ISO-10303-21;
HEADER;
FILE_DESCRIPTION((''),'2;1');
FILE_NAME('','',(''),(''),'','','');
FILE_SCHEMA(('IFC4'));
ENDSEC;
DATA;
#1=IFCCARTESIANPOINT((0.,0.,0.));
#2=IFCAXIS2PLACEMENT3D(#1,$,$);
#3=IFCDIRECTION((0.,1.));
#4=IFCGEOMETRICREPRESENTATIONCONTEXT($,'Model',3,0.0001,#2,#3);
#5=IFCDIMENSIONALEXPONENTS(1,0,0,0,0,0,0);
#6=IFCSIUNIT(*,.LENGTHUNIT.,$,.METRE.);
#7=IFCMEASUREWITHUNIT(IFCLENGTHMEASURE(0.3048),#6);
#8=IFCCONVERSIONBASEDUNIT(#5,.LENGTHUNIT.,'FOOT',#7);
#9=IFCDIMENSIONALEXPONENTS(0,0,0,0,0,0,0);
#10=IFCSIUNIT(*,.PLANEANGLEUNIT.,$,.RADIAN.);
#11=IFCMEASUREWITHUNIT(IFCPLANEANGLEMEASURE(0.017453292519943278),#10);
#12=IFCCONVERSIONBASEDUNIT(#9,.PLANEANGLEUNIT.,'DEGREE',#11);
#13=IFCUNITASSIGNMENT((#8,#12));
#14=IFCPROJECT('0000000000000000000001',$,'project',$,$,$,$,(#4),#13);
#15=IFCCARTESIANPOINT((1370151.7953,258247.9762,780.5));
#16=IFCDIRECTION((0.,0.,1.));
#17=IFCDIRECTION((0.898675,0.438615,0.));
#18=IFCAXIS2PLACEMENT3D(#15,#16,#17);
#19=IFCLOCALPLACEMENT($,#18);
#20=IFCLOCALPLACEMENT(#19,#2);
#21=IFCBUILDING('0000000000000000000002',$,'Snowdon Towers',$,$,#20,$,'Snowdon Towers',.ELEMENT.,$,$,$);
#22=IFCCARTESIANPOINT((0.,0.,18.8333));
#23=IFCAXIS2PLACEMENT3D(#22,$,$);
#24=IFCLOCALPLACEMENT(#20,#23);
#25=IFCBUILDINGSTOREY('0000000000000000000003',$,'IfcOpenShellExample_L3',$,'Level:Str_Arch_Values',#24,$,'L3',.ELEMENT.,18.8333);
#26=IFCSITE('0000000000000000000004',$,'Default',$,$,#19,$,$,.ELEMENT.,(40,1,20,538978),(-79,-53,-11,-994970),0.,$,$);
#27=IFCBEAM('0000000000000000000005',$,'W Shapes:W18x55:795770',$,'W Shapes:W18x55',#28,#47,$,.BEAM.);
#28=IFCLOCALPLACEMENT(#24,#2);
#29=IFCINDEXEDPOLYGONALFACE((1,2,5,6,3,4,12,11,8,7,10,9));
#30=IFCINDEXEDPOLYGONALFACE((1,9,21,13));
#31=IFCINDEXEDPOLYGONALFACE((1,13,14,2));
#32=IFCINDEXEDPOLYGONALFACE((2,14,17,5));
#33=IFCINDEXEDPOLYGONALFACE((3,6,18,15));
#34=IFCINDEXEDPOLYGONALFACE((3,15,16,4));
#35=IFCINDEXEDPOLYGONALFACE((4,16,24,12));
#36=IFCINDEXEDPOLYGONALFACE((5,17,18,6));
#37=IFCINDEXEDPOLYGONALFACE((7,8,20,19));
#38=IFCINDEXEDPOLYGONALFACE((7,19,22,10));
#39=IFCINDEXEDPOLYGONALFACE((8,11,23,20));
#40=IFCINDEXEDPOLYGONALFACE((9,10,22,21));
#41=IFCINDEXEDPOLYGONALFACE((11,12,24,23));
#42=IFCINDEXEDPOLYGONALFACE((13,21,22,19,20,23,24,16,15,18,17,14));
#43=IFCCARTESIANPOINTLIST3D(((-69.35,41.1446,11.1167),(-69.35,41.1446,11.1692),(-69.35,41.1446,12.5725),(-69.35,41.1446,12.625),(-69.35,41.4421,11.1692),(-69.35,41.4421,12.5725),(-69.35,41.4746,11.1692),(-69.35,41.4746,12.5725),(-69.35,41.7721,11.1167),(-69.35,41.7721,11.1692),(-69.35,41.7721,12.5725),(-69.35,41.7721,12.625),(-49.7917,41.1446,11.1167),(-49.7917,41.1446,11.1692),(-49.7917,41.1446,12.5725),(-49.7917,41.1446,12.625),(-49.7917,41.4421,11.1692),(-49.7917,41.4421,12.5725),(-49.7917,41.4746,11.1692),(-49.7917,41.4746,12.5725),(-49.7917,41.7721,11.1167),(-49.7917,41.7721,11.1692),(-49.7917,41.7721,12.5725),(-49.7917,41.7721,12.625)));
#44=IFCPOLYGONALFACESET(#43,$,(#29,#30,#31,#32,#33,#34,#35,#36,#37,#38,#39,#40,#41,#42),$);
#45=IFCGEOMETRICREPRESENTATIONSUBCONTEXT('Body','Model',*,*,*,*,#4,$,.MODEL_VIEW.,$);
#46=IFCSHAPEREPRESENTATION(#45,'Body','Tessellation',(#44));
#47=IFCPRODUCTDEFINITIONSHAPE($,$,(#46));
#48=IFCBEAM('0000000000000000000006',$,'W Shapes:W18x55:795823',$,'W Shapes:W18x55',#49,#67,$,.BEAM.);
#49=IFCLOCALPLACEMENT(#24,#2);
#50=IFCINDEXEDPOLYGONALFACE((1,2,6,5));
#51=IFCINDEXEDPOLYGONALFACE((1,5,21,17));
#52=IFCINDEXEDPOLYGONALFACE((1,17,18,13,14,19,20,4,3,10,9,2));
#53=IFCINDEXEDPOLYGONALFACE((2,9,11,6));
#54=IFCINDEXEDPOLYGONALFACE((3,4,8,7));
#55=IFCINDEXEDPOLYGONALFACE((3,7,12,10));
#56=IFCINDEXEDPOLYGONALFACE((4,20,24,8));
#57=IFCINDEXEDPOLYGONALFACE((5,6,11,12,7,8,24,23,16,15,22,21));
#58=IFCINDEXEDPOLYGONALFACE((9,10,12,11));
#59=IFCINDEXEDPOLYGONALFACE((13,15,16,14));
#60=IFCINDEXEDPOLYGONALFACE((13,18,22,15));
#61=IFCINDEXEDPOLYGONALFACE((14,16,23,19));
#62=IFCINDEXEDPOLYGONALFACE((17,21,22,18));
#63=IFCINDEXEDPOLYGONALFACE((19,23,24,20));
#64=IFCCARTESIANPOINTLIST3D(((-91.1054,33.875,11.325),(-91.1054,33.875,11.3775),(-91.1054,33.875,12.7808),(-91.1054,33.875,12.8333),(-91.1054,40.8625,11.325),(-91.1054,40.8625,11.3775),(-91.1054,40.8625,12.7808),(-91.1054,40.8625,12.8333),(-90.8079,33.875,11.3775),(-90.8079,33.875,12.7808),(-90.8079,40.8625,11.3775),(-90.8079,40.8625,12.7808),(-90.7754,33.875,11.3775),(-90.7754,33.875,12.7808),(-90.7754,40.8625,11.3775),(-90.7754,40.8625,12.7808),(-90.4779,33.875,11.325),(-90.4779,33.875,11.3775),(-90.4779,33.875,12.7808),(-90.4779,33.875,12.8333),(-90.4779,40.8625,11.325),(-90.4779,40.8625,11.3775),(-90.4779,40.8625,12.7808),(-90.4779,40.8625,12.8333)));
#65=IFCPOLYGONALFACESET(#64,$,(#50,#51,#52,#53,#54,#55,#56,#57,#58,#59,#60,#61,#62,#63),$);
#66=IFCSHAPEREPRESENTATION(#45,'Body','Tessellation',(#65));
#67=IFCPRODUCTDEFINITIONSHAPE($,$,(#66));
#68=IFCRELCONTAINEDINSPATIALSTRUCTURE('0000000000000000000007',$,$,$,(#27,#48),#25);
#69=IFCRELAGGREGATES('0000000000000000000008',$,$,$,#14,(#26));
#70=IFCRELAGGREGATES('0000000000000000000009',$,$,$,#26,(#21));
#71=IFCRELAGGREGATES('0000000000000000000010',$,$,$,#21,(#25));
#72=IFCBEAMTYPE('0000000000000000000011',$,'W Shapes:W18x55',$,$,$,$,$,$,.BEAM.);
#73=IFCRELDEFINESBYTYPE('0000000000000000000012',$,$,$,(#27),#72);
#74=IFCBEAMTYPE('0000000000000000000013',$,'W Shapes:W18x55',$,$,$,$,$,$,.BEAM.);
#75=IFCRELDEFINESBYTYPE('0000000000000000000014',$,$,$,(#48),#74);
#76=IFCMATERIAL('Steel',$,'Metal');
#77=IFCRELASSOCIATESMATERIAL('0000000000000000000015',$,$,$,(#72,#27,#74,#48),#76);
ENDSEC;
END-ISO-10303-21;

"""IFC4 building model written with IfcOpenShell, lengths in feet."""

from ifc_helpers import new_model, entity, si_unit, converted_unit, direction, frame, origin, place, context, subcontext, project, spatial, indexed_curve, outline, extrude, source, transform, mapped, material, type_object, type_shapes, element, save


model = new_model("IFC4")

# Units and contexts
model_context = context("Model", 3, precision=0.0001, world=origin(), true_north=direction((0.0, 1.0)))
body_context = subcontext(model_context, "Body", "Model", "MODEL_VIEW")
ifc_project = project(units=[converted_unit("LENGTHUNIT", "FOOT", entity("IfcLengthMeasure", 0.3048), si_unit("LENGTHUNIT", "METRE"), dimensions=[1, 0, 0, 0, 0, 0, 0]), converted_unit("PLANEANGLEUNIT", "DEGREE", entity("IfcPlaneAngleMeasure", 0.017453292519943278), si_unit("PLANEANGLEUNIT", "RADIAN"), dimensions=[0, 0, 0, 0, 0, 0, 0])], contexts=[model_context])

# Site, building, storey
site_placement = place(None, frame((1370151.7953, 258247.9762, 780.5), z_axis=(0.0, 0.0, 1.0), x_axis=(0.898675, 0.438615, 0.0)))
site = spatial("IfcSite", under=ifc_project, at=site_placement, Name="Default", CompositionType="ELEMENT", RefLatitude=(40, 1, 20, 538978), RefLongitude=(-79, -53, -11, -994970), RefElevation=0.0)
building_placement = place(site_placement, origin())
building = spatial("IfcBuilding", under=site, at=building_placement, Name="Snowdon Towers", LongName="Snowdon Towers", CompositionType="ELEMENT")
storey_placement = place(building_placement, frame((0.0, 0.0, 18.8333)))
storey = spatial("IfcBuildingStorey", under=building, at=storey_placement, Name="IfcOpenShellExample_L3", ObjectType="Level:Str_Arch_Values", LongName="L3", CompositionType="ELEMENT", Elevation=18.8333)

# Beam
ifc_material = material(Name="Steel", Category="Metal")
beam_type_1 = type_object("IfcBeamType", Name="W Shapes:W18x55", PredefinedType="BEAM", material=ifc_material)
shared_shape_1 = source(origin(), body_context, "Body", "SweptSolid", [
    extrude(outline(indexed_curve([(-0.3138, -0.7017), (-0.3138, -0.7542), (0.3138, -0.7542), (0.3138, -0.7017), (0.0162, -0.7017), (0.0162, 0.7017), (0.3138, 0.7017), (0.3138, 0.7542), (-0.3137, 0.7542), (-0.3137, 0.7017), (-0.0163, 0.7017), (-0.0163, -0.7017), (-0.3138, -0.7017)], self_intersect=False)), frame((-9.725, 0.0, 0.0), z_axis=(-1.0, 0.0, 0.0), x_axis=(0.0, -1.0, 0.0)), (0.0, 0.0, -1.0), 19.5583),
])
type_shapes(beam_type_1, [shared_shape_1])
beam_1_placement = place(storey_placement, frame((-59.625, 41.4583, 11.8708)))
element("IfcBeam", 1, at=beam_1_placement, inside=storey, type_object=beam_type_1, material=ifc_material, Name="W Shapes:W18x55:795770", ObjectType="W Shapes:W18x55", PredefinedType="BEAM", context=body_context, shape_type="MappedRepresentation", body=[
    mapped(shared_shape_1, transform((0.0, 0.0, 0.0), scale=1.0)),
])

# Beam
beam_type_2 = type_object("IfcBeamType", Name="W Shapes:W18x55", PredefinedType="BEAM", material=ifc_material)
shared_shape_2 = source(origin(), body_context, "Body", "SweptSolid", [
    extrude(outline(indexed_curve([(-0.3138, -0.7017), (-0.3138, -0.7542), (0.3138, -0.7542), (0.3138, -0.7017), (0.0162, -0.7017), (0.0162, 0.7017), (0.3138, 0.7017), (0.3138, 0.7542), (-0.3137, 0.7542), (-0.3137, 0.7017), (-0.0163, 0.7017), (-0.0163, -0.7017), (-0.3138, -0.7017)], self_intersect=False)), frame((-3.1958, 0.0, 0.0), z_axis=(-1.0, 0.0, 0.0), x_axis=(0.0, -1.0, 0.0)), (0.0, 0.0, -1.0), 6.9875),
])
type_shapes(beam_type_2, [shared_shape_2])
beam_2_placement = place(storey_placement, frame((-90.7917, 37.6667, 12.0792), z_axis=(0.0, 0.0, 1.0), x_axis=(0.0, -1.0, 0.0)))
element("IfcBeam", 2, at=beam_2_placement, inside=storey, type_object=beam_type_2, material=ifc_material, Name="W Shapes:W18x55:795823", ObjectType="W Shapes:W18x55", PredefinedType="BEAM", context=body_context, shape_type="MappedRepresentation", body=[
    mapped(shared_shape_2, transform((0.0, 0.0, 0.0), scale=1.0)),
])

save(model, "model.ifc")
